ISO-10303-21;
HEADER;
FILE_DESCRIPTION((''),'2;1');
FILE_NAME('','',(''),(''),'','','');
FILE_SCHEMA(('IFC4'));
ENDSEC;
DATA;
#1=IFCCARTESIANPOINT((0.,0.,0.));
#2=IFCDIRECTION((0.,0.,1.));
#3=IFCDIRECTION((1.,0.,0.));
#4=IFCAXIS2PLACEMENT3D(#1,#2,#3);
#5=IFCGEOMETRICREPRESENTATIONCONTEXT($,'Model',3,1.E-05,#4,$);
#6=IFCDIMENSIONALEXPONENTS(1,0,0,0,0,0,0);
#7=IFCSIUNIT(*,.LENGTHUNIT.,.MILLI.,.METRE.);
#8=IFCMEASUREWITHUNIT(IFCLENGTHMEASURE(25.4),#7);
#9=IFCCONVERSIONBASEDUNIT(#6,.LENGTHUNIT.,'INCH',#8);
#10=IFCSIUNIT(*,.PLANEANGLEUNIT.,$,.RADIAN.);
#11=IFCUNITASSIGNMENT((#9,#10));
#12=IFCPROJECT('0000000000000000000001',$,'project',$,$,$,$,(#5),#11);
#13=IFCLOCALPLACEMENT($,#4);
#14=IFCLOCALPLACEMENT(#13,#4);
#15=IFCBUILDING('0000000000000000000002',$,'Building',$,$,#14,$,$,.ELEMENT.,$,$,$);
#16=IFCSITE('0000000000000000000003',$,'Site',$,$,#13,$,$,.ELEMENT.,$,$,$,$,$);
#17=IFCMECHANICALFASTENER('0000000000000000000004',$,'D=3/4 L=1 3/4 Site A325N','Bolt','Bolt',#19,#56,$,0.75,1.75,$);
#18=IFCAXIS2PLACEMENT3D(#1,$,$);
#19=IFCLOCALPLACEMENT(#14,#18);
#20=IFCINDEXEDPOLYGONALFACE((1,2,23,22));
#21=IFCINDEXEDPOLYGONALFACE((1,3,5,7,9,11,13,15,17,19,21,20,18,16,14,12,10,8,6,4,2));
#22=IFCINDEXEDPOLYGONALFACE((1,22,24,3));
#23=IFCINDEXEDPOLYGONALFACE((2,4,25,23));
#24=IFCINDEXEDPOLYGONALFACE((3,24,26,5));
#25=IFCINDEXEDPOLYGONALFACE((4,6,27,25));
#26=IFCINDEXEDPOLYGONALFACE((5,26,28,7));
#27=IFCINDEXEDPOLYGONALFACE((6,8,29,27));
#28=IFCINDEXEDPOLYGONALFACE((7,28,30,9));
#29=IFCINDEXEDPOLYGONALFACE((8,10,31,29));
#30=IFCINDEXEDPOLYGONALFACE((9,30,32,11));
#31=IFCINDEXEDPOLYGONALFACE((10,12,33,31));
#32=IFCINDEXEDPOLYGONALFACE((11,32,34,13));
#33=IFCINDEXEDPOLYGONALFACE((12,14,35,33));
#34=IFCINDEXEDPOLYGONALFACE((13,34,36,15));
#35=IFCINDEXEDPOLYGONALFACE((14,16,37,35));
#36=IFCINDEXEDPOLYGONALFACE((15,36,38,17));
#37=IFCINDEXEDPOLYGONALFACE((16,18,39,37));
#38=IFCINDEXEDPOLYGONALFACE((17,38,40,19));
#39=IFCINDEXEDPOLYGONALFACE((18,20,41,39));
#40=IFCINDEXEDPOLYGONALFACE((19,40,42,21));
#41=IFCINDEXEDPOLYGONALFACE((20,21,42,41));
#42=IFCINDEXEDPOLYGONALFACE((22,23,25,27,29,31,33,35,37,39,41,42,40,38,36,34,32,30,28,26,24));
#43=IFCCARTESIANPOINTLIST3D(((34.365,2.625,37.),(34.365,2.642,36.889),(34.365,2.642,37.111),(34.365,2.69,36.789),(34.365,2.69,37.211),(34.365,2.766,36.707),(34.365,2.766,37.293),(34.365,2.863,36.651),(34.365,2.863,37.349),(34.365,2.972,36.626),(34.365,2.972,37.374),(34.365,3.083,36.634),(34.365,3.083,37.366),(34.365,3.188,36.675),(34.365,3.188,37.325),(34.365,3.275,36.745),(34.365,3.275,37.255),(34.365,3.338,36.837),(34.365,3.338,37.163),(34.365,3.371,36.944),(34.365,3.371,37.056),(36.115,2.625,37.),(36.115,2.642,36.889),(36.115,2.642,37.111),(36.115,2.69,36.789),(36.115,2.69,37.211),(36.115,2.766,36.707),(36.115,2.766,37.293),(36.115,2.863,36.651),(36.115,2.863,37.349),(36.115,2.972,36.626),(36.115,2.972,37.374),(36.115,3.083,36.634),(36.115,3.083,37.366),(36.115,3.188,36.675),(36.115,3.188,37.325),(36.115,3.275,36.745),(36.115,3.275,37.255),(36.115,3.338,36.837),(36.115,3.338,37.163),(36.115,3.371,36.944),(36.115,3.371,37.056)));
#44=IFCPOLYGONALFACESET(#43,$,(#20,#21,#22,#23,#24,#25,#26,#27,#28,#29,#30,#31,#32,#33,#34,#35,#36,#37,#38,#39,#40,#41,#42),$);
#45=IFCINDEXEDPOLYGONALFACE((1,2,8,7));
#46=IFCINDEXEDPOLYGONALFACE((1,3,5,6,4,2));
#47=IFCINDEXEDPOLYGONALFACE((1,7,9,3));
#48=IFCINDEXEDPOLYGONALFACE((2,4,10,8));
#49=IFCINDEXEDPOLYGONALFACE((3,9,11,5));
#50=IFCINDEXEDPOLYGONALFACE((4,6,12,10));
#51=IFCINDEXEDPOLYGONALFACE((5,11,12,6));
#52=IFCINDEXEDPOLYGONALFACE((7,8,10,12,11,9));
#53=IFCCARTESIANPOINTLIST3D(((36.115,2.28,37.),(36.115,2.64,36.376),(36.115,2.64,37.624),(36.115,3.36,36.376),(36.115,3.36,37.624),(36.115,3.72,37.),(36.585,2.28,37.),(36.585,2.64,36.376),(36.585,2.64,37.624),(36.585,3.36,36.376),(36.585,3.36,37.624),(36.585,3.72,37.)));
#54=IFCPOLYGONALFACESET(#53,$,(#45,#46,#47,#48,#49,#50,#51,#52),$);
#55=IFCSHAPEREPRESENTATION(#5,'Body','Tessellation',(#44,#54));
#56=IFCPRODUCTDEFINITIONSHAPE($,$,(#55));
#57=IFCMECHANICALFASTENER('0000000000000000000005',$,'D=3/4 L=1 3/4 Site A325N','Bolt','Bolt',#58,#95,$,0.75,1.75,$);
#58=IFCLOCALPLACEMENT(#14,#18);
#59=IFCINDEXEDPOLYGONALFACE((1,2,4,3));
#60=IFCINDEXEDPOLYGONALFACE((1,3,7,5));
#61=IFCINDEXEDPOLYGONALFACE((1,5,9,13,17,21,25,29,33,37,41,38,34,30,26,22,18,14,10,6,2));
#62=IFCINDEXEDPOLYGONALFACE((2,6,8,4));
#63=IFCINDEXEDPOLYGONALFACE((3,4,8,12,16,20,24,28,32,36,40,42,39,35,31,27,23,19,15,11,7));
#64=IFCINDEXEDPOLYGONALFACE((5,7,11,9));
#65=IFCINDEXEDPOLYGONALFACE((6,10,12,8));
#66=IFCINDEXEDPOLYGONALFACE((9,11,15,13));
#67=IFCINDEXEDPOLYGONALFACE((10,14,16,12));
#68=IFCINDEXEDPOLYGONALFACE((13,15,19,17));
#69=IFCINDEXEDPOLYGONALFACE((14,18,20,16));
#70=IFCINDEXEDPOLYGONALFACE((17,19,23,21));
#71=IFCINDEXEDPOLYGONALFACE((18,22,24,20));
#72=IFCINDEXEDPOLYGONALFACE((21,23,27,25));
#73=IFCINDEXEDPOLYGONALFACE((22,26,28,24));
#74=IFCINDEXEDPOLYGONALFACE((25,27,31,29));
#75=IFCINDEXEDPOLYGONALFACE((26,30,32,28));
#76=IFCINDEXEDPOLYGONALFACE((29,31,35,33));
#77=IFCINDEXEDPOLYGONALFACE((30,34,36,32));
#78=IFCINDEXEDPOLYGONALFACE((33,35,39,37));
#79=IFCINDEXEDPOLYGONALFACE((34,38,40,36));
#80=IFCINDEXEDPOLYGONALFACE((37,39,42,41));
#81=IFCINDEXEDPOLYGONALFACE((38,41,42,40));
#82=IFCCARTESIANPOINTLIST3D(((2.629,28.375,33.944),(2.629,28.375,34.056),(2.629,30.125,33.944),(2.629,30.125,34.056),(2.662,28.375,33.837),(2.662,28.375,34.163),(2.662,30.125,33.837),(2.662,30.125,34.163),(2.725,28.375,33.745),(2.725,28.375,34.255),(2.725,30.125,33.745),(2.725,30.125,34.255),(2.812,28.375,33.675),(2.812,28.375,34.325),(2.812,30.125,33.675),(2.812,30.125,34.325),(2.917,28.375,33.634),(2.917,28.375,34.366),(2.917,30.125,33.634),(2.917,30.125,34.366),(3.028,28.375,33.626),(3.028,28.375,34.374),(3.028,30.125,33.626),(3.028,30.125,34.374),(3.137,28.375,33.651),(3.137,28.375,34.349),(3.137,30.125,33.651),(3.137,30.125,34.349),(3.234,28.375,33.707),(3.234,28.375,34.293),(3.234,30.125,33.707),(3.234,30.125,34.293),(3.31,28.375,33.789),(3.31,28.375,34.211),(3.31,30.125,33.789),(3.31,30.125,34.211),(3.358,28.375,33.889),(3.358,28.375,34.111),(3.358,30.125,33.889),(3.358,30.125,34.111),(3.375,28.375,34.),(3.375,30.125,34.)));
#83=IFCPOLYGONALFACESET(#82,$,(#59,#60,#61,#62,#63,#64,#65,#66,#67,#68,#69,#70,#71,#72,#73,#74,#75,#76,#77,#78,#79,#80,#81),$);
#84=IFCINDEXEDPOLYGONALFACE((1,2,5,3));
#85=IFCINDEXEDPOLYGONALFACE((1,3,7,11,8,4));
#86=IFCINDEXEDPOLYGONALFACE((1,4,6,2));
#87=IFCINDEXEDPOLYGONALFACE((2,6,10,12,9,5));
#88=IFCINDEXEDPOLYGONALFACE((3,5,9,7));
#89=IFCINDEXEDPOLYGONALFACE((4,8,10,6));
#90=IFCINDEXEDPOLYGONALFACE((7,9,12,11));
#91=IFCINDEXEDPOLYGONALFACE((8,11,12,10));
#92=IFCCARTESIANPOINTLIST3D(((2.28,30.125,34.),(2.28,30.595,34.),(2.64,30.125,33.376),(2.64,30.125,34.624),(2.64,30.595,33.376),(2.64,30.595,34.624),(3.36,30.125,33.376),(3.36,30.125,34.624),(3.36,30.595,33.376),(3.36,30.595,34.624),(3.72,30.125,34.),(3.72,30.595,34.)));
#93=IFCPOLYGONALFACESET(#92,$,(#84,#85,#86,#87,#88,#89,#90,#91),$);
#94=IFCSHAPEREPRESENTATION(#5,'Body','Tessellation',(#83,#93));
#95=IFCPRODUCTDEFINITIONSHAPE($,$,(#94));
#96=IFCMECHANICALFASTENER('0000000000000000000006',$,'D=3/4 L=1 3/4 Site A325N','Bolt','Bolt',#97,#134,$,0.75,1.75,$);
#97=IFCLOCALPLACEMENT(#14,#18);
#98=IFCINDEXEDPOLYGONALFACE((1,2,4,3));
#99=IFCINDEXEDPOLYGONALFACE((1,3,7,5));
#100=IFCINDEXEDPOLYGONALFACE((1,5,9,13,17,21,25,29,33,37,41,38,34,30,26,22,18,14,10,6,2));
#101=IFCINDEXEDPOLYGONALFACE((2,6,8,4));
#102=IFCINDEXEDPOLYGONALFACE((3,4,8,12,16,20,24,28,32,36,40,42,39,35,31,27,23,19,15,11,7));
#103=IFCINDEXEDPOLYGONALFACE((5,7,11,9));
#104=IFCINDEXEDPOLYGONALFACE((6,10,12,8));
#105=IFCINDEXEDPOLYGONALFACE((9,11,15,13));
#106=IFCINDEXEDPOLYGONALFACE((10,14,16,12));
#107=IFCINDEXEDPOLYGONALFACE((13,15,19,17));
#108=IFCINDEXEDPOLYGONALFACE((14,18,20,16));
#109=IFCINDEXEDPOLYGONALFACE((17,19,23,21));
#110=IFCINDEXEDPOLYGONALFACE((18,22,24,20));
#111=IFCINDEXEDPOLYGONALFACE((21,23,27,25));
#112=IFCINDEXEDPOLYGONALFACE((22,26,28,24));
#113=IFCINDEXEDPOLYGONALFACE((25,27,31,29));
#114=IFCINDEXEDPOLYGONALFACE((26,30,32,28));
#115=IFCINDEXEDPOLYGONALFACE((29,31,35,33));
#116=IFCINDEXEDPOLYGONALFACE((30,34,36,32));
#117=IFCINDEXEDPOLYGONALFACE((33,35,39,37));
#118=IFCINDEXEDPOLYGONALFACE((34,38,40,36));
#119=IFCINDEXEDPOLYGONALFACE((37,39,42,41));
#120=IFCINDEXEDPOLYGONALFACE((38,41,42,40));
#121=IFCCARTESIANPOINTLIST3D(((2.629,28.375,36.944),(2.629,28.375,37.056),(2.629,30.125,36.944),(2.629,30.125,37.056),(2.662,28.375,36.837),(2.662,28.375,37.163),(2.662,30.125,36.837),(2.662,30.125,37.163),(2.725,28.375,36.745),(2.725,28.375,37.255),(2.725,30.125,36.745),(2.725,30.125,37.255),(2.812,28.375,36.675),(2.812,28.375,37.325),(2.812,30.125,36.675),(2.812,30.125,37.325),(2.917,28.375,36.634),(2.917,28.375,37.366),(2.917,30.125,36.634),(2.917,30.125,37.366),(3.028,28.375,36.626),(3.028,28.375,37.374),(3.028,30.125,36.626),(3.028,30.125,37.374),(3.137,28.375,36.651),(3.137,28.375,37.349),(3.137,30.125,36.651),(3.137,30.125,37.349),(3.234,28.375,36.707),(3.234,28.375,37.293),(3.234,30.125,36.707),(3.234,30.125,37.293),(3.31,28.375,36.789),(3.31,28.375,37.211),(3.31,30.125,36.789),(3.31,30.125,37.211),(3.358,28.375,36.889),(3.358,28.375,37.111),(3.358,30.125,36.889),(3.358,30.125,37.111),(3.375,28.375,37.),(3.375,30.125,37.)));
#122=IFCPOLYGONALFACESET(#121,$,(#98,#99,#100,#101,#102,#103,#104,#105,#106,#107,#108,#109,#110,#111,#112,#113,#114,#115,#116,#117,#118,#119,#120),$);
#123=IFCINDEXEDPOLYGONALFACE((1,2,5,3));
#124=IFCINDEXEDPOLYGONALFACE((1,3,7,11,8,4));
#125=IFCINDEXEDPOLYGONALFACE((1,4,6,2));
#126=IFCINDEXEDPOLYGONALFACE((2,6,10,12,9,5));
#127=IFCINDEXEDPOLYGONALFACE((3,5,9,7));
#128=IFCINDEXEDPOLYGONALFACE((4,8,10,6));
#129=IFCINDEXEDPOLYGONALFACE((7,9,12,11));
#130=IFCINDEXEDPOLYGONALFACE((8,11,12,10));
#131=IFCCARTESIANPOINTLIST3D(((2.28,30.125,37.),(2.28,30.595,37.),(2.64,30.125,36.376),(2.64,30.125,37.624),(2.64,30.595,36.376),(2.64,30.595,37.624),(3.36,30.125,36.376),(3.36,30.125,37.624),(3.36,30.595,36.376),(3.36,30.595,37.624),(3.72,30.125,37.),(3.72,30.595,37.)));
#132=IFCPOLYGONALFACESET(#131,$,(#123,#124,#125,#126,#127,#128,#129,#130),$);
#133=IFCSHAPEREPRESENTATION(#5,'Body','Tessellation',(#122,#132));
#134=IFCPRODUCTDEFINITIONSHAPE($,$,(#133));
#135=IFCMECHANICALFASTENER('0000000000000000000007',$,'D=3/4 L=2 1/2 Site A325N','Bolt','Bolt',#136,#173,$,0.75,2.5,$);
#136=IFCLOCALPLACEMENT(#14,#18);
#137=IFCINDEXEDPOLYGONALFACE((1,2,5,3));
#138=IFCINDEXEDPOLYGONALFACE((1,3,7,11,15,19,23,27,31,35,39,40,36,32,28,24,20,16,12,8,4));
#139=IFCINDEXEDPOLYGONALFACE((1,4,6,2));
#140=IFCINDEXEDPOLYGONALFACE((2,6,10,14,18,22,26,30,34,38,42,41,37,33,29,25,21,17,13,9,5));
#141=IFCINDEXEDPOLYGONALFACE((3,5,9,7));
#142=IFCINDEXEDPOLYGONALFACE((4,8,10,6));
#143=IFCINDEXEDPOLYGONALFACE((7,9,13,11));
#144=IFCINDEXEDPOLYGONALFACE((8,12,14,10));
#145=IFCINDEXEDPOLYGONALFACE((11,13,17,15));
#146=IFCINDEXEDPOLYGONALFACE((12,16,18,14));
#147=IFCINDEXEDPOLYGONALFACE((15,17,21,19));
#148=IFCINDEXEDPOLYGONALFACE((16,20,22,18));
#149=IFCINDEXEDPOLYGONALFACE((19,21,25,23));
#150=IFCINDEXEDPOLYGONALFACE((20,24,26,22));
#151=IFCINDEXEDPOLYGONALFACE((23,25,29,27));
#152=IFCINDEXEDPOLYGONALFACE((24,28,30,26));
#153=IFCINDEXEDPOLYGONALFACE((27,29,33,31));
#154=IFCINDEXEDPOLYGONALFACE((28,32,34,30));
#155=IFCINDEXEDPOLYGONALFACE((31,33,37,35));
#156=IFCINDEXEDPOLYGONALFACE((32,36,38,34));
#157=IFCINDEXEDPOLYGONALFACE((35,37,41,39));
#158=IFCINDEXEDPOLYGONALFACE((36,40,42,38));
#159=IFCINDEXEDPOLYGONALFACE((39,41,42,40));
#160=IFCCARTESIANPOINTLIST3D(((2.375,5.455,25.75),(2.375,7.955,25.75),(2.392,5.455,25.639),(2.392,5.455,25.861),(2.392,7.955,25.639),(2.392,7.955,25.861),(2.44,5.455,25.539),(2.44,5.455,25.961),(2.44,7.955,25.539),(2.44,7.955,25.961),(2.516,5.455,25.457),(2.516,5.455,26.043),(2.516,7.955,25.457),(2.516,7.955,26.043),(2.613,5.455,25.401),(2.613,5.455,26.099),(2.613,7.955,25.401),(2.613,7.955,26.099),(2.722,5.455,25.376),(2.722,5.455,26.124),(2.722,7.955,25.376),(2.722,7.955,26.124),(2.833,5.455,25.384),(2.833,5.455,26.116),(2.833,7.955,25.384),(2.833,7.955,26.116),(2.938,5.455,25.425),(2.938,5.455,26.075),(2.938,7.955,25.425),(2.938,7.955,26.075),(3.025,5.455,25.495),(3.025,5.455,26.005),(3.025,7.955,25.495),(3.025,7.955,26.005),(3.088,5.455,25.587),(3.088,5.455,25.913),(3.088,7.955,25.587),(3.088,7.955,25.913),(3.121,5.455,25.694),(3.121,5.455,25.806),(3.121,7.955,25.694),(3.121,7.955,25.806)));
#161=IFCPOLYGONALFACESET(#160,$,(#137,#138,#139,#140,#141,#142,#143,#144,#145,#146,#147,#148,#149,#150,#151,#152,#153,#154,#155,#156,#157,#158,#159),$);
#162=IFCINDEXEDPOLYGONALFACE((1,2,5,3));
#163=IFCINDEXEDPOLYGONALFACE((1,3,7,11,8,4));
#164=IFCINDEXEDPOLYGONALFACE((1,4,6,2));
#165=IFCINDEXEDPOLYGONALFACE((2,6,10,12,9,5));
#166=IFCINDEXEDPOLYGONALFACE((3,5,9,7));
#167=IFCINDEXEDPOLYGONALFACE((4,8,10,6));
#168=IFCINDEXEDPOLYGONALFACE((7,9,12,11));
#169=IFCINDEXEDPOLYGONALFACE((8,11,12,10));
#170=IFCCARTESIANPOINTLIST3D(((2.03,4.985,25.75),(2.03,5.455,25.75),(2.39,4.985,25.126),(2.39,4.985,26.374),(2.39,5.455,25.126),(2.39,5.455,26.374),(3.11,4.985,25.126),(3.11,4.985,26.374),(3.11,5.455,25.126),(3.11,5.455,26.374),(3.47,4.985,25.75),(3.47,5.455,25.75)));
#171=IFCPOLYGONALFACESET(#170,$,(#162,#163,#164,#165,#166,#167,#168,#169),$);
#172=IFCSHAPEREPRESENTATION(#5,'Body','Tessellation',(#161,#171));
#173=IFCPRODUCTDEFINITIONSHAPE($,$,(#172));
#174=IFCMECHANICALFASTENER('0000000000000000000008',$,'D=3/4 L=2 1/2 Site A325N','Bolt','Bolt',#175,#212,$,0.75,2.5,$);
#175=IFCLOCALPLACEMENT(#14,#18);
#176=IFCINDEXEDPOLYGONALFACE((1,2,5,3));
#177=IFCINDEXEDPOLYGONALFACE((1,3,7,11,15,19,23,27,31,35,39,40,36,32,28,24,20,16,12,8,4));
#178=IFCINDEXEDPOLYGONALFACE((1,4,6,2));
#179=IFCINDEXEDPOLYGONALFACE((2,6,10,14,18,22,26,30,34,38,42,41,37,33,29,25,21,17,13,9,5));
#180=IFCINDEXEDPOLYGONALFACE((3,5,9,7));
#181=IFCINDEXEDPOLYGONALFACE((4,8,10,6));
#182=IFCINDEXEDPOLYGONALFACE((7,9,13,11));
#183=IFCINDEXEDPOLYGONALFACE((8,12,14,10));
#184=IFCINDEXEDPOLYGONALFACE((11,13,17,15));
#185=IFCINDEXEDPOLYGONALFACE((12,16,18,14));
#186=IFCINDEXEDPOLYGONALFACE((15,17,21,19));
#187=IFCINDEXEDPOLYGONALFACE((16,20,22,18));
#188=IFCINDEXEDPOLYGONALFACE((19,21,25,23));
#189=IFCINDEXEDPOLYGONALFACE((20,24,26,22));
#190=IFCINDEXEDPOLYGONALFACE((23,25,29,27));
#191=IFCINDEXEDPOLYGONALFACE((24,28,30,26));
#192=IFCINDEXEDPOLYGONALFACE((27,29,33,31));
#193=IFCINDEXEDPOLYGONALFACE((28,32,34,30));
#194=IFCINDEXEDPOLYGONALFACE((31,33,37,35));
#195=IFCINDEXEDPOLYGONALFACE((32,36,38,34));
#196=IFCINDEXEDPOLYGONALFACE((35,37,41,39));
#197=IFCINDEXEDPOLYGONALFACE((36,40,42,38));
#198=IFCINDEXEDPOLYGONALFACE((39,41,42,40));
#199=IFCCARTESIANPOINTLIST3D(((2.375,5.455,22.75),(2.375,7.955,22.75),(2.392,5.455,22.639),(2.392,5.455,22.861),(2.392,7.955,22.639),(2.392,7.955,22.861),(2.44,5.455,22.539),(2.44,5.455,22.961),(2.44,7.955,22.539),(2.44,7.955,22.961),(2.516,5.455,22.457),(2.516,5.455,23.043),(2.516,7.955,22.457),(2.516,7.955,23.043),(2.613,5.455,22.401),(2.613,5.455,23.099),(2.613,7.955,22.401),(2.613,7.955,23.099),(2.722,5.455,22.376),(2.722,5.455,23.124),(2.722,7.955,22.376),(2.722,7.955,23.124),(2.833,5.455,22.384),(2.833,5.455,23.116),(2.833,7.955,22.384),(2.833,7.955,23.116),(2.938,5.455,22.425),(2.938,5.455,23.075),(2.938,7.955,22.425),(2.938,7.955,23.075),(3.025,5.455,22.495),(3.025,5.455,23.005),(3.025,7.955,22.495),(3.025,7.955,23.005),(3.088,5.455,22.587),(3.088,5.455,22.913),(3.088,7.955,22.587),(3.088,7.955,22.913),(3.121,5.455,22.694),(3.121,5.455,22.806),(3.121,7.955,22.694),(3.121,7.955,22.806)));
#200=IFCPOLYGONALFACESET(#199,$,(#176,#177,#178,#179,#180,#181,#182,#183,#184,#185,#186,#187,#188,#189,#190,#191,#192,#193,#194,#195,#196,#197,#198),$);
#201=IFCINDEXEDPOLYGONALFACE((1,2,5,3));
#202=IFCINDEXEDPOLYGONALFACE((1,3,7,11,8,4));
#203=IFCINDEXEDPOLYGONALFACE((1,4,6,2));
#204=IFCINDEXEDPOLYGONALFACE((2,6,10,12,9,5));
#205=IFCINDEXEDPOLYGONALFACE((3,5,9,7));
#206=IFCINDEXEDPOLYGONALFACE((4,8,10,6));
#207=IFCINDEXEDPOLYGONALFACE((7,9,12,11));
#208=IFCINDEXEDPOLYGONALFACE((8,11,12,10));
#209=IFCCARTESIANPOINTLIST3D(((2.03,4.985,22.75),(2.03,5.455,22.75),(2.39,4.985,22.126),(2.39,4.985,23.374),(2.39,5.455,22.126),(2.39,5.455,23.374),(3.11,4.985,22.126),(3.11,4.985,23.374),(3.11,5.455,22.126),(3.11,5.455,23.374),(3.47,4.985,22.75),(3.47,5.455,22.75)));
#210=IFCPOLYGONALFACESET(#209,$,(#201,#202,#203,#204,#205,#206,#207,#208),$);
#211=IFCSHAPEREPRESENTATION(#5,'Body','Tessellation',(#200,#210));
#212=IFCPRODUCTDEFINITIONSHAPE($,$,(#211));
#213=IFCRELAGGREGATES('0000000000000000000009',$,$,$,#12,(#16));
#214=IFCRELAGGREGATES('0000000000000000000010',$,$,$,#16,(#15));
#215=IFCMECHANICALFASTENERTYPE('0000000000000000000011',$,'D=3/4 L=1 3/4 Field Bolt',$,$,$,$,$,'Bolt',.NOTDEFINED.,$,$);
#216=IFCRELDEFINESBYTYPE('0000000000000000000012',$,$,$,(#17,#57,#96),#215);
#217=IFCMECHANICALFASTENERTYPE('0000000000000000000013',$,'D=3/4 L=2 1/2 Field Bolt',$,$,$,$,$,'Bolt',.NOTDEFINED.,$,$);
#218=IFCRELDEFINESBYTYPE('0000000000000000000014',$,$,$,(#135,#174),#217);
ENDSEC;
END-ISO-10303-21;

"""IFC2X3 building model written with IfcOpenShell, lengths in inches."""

from ifc_helpers import new_model, entity, si_unit, converted_unit, frame, origin_with_axes, origin_2d_with_axis, place, context, project, spatial, polyline, circle, outline, extrude, source, transform, mapped, type_object, type_shapes, element, save


model = new_model("IFC2X3")

# Units and contexts
model_context = context("Model", 3, precision=1e-05, world=origin_with_axes())
ifc_project = project(units=[converted_unit("LENGTHUNIT", "INCH", entity("IfcLengthMeasure", 25.4), si_unit("LENGTHUNIT", "METRE", prefix="MILLI"), dimensions=[1, 0, 0, 0, 0, 0, 0]), si_unit("PLANEANGLEUNIT", "RADIAN")], contexts=[model_context])

# Site, building
site_placement = place(None, origin_with_axes())
site = spatial("IfcSite", under=ifc_project, at=site_placement, Name="Site", CompositionType="ELEMENT")
building_placement = place(site_placement, origin_with_axes())
building = spatial("IfcBuilding", under=site, at=building_placement, Name="Building", CompositionType="ELEMENT")

# Shared definitions
assembly_1_placement = place(building_placement, frame((0.0, 0.0, 21.0), z_axis=(0.0, -1.0, 0.0), x_axis=(0.0, 0.0, 1.0)))

# Mechanical fasteners
mechanical_fastener_type_1 = type_object("IfcMechanicalFastenerType", Name="D=3/4 L=1 3/4 Field Bolt", ElementType="Bolt")
shared_shape_1 = source(origin_with_axes(), model_context, "Body", "SweptSolid", [
    extrude(circle(Radius=0.375, at=origin_2d_with_axis()), frame((0.0, 0.0, 0.0), z_axis=(1.0, 0.0, 0.0), x_axis=(0.0, 1.0, 0.0)), (0.0, 0.0, 1.0), 1.75),
    extrude(outline(polyline([(-0.72, 0.0), (-0.36, 0.624), (0.36, 0.624), (0.72, 0.0), (0.36, -0.624), (-0.36, -0.624), (-0.72, 0.0)])), frame((0.0, 0.0, 0.0), z_axis=(1.0, 0.0, 0.0), x_axis=(0.0, 1.0, 0.0)), (0.0, 0.0, -1.0), 0.47),
])
type_shapes(mechanical_fastener_type_1, [shared_shape_1])
placement_1 = place(building_placement, frame((36.0, 0.0, 43.0), z_axis=(0.0, 0.0, 1.0), x_axis=(0.0, 1.0, 0.0)))
placement_2 = place(placement_1, frame((3.0, -0.115, -3.0), z_axis=(0.0, 0.0, 1.0), x_axis=(0.0, 1.0, 0.0)))
for number, where, z_axis, x_axis, name in (
    (1, (0.0, 0.0, -3.0), (0.0, 0.0, 1.0), (1.0, 0.0, 0.0), "D=3/4 L=1 3/4 Site A325N"),
):
    element("IfcMechanicalFastener", number, at=place(placement_2, frame(where, z_axis=z_axis, x_axis=x_axis)), type_object=mechanical_fastener_type_1, Name=name, Description="Bolt", ObjectType="Bolt", NominalDiameter=0.75, NominalLength=1.75, context=model_context, shape_type="MappedRepresentation", body=[
        mapped(shared_shape_1, transform((0.0, 0.0, 0.0), scale=1.0)),
    ])
placement_3 = place(building_placement, frame((0.0, 30.0, 46.0), z_axis=(0.0, 0.0, 1.0), x_axis=(1.0, 0.0, 0.0)))
placement_4 = place(placement_3, frame((3.0, 0.125, -3.0), z_axis=(0.0, 0.0, 1.0), x_axis=(0.0, -1.0, 0.0)))
for number, where, z_axis, x_axis, name in (
    (2, (0.0, 0.0, -9.0), (0.0, 0.0, 1.0), (1.0, 0.0, 0.0), "D=3/4 L=1 3/4 Site A325N"),
    (3, (0.0, 0.0, -6.0), (0.0, 0.0, 1.0), (1.0, 0.0, 0.0), "D=3/4 L=1 3/4 Site A325N"),
):
    element("IfcMechanicalFastener", number, at=place(placement_4, frame(where, z_axis=z_axis, x_axis=x_axis)), type_object=mechanical_fastener_type_1, Name=name, Description="Bolt", ObjectType="Bolt", NominalDiameter=0.75, NominalLength=1.75, context=model_context, shape_type="MappedRepresentation", body=[
        mapped(shared_shape_1, transform((0.0, 0.0, 0.0), scale=1.0)),
    ])
mechanical_fastener_type_2 = type_object("IfcMechanicalFastenerType", Name="D=3/4 L=2 1/2 Field Bolt", ElementType="Bolt")
shared_shape_2 = source(origin_with_axes(), model_context, "Body", "SweptSolid", [
    extrude(circle(Radius=0.375, at=origin_2d_with_axis()), frame((0.0, 0.0, 0.0), z_axis=(1.0, 0.0, 0.0), x_axis=(0.0, 1.0, 0.0)), (0.0, 0.0, 1.0), 2.5),
    extrude(outline(polyline([(-0.72, 0.0), (-0.36, 0.624), (0.36, 0.624), (0.72, 0.0), (0.36, -0.624), (-0.36, -0.624), (-0.72, 0.0)])), frame((0.0, 0.0, 0.0), z_axis=(1.0, 0.0, 0.0), x_axis=(0.0, 1.0, 0.0)), (0.0, 0.0, -1.0), 0.47),
])
type_shapes(mechanical_fastener_type_2, [shared_shape_2])
placement_5 = place(assembly_1_placement, frame((4.75, -2.75, -5.455), z_axis=(1.0, 0.0, 0.0), x_axis=(0.0, 0.0, -1.0)))
for number, where, z_axis, x_axis, name in (
    (4, (0.0, 0.0, 0.0), (0.0, 0.0, 1.0), (1.0, 0.0, 0.0), "D=3/4 L=2 1/2 Site A325N"),
    (5, (0.0, 0.0, -3.0), (0.0, 0.0, 1.0), (1.0, 0.0, 0.0), "D=3/4 L=2 1/2 Site A325N"),
):
    element("IfcMechanicalFastener", number, at=place(placement_5, frame(where, z_axis=z_axis, x_axis=x_axis)), type_object=mechanical_fastener_type_2, Name=name, Description="Bolt", ObjectType="Bolt", NominalDiameter=0.75, NominalLength=2.5, context=model_context, shape_type="MappedRepresentation", body=[
        mapped(shared_shape_2, transform((0.0, 0.0, 0.0), scale=1.0)),
    ])

save(model, "model.ifc")
